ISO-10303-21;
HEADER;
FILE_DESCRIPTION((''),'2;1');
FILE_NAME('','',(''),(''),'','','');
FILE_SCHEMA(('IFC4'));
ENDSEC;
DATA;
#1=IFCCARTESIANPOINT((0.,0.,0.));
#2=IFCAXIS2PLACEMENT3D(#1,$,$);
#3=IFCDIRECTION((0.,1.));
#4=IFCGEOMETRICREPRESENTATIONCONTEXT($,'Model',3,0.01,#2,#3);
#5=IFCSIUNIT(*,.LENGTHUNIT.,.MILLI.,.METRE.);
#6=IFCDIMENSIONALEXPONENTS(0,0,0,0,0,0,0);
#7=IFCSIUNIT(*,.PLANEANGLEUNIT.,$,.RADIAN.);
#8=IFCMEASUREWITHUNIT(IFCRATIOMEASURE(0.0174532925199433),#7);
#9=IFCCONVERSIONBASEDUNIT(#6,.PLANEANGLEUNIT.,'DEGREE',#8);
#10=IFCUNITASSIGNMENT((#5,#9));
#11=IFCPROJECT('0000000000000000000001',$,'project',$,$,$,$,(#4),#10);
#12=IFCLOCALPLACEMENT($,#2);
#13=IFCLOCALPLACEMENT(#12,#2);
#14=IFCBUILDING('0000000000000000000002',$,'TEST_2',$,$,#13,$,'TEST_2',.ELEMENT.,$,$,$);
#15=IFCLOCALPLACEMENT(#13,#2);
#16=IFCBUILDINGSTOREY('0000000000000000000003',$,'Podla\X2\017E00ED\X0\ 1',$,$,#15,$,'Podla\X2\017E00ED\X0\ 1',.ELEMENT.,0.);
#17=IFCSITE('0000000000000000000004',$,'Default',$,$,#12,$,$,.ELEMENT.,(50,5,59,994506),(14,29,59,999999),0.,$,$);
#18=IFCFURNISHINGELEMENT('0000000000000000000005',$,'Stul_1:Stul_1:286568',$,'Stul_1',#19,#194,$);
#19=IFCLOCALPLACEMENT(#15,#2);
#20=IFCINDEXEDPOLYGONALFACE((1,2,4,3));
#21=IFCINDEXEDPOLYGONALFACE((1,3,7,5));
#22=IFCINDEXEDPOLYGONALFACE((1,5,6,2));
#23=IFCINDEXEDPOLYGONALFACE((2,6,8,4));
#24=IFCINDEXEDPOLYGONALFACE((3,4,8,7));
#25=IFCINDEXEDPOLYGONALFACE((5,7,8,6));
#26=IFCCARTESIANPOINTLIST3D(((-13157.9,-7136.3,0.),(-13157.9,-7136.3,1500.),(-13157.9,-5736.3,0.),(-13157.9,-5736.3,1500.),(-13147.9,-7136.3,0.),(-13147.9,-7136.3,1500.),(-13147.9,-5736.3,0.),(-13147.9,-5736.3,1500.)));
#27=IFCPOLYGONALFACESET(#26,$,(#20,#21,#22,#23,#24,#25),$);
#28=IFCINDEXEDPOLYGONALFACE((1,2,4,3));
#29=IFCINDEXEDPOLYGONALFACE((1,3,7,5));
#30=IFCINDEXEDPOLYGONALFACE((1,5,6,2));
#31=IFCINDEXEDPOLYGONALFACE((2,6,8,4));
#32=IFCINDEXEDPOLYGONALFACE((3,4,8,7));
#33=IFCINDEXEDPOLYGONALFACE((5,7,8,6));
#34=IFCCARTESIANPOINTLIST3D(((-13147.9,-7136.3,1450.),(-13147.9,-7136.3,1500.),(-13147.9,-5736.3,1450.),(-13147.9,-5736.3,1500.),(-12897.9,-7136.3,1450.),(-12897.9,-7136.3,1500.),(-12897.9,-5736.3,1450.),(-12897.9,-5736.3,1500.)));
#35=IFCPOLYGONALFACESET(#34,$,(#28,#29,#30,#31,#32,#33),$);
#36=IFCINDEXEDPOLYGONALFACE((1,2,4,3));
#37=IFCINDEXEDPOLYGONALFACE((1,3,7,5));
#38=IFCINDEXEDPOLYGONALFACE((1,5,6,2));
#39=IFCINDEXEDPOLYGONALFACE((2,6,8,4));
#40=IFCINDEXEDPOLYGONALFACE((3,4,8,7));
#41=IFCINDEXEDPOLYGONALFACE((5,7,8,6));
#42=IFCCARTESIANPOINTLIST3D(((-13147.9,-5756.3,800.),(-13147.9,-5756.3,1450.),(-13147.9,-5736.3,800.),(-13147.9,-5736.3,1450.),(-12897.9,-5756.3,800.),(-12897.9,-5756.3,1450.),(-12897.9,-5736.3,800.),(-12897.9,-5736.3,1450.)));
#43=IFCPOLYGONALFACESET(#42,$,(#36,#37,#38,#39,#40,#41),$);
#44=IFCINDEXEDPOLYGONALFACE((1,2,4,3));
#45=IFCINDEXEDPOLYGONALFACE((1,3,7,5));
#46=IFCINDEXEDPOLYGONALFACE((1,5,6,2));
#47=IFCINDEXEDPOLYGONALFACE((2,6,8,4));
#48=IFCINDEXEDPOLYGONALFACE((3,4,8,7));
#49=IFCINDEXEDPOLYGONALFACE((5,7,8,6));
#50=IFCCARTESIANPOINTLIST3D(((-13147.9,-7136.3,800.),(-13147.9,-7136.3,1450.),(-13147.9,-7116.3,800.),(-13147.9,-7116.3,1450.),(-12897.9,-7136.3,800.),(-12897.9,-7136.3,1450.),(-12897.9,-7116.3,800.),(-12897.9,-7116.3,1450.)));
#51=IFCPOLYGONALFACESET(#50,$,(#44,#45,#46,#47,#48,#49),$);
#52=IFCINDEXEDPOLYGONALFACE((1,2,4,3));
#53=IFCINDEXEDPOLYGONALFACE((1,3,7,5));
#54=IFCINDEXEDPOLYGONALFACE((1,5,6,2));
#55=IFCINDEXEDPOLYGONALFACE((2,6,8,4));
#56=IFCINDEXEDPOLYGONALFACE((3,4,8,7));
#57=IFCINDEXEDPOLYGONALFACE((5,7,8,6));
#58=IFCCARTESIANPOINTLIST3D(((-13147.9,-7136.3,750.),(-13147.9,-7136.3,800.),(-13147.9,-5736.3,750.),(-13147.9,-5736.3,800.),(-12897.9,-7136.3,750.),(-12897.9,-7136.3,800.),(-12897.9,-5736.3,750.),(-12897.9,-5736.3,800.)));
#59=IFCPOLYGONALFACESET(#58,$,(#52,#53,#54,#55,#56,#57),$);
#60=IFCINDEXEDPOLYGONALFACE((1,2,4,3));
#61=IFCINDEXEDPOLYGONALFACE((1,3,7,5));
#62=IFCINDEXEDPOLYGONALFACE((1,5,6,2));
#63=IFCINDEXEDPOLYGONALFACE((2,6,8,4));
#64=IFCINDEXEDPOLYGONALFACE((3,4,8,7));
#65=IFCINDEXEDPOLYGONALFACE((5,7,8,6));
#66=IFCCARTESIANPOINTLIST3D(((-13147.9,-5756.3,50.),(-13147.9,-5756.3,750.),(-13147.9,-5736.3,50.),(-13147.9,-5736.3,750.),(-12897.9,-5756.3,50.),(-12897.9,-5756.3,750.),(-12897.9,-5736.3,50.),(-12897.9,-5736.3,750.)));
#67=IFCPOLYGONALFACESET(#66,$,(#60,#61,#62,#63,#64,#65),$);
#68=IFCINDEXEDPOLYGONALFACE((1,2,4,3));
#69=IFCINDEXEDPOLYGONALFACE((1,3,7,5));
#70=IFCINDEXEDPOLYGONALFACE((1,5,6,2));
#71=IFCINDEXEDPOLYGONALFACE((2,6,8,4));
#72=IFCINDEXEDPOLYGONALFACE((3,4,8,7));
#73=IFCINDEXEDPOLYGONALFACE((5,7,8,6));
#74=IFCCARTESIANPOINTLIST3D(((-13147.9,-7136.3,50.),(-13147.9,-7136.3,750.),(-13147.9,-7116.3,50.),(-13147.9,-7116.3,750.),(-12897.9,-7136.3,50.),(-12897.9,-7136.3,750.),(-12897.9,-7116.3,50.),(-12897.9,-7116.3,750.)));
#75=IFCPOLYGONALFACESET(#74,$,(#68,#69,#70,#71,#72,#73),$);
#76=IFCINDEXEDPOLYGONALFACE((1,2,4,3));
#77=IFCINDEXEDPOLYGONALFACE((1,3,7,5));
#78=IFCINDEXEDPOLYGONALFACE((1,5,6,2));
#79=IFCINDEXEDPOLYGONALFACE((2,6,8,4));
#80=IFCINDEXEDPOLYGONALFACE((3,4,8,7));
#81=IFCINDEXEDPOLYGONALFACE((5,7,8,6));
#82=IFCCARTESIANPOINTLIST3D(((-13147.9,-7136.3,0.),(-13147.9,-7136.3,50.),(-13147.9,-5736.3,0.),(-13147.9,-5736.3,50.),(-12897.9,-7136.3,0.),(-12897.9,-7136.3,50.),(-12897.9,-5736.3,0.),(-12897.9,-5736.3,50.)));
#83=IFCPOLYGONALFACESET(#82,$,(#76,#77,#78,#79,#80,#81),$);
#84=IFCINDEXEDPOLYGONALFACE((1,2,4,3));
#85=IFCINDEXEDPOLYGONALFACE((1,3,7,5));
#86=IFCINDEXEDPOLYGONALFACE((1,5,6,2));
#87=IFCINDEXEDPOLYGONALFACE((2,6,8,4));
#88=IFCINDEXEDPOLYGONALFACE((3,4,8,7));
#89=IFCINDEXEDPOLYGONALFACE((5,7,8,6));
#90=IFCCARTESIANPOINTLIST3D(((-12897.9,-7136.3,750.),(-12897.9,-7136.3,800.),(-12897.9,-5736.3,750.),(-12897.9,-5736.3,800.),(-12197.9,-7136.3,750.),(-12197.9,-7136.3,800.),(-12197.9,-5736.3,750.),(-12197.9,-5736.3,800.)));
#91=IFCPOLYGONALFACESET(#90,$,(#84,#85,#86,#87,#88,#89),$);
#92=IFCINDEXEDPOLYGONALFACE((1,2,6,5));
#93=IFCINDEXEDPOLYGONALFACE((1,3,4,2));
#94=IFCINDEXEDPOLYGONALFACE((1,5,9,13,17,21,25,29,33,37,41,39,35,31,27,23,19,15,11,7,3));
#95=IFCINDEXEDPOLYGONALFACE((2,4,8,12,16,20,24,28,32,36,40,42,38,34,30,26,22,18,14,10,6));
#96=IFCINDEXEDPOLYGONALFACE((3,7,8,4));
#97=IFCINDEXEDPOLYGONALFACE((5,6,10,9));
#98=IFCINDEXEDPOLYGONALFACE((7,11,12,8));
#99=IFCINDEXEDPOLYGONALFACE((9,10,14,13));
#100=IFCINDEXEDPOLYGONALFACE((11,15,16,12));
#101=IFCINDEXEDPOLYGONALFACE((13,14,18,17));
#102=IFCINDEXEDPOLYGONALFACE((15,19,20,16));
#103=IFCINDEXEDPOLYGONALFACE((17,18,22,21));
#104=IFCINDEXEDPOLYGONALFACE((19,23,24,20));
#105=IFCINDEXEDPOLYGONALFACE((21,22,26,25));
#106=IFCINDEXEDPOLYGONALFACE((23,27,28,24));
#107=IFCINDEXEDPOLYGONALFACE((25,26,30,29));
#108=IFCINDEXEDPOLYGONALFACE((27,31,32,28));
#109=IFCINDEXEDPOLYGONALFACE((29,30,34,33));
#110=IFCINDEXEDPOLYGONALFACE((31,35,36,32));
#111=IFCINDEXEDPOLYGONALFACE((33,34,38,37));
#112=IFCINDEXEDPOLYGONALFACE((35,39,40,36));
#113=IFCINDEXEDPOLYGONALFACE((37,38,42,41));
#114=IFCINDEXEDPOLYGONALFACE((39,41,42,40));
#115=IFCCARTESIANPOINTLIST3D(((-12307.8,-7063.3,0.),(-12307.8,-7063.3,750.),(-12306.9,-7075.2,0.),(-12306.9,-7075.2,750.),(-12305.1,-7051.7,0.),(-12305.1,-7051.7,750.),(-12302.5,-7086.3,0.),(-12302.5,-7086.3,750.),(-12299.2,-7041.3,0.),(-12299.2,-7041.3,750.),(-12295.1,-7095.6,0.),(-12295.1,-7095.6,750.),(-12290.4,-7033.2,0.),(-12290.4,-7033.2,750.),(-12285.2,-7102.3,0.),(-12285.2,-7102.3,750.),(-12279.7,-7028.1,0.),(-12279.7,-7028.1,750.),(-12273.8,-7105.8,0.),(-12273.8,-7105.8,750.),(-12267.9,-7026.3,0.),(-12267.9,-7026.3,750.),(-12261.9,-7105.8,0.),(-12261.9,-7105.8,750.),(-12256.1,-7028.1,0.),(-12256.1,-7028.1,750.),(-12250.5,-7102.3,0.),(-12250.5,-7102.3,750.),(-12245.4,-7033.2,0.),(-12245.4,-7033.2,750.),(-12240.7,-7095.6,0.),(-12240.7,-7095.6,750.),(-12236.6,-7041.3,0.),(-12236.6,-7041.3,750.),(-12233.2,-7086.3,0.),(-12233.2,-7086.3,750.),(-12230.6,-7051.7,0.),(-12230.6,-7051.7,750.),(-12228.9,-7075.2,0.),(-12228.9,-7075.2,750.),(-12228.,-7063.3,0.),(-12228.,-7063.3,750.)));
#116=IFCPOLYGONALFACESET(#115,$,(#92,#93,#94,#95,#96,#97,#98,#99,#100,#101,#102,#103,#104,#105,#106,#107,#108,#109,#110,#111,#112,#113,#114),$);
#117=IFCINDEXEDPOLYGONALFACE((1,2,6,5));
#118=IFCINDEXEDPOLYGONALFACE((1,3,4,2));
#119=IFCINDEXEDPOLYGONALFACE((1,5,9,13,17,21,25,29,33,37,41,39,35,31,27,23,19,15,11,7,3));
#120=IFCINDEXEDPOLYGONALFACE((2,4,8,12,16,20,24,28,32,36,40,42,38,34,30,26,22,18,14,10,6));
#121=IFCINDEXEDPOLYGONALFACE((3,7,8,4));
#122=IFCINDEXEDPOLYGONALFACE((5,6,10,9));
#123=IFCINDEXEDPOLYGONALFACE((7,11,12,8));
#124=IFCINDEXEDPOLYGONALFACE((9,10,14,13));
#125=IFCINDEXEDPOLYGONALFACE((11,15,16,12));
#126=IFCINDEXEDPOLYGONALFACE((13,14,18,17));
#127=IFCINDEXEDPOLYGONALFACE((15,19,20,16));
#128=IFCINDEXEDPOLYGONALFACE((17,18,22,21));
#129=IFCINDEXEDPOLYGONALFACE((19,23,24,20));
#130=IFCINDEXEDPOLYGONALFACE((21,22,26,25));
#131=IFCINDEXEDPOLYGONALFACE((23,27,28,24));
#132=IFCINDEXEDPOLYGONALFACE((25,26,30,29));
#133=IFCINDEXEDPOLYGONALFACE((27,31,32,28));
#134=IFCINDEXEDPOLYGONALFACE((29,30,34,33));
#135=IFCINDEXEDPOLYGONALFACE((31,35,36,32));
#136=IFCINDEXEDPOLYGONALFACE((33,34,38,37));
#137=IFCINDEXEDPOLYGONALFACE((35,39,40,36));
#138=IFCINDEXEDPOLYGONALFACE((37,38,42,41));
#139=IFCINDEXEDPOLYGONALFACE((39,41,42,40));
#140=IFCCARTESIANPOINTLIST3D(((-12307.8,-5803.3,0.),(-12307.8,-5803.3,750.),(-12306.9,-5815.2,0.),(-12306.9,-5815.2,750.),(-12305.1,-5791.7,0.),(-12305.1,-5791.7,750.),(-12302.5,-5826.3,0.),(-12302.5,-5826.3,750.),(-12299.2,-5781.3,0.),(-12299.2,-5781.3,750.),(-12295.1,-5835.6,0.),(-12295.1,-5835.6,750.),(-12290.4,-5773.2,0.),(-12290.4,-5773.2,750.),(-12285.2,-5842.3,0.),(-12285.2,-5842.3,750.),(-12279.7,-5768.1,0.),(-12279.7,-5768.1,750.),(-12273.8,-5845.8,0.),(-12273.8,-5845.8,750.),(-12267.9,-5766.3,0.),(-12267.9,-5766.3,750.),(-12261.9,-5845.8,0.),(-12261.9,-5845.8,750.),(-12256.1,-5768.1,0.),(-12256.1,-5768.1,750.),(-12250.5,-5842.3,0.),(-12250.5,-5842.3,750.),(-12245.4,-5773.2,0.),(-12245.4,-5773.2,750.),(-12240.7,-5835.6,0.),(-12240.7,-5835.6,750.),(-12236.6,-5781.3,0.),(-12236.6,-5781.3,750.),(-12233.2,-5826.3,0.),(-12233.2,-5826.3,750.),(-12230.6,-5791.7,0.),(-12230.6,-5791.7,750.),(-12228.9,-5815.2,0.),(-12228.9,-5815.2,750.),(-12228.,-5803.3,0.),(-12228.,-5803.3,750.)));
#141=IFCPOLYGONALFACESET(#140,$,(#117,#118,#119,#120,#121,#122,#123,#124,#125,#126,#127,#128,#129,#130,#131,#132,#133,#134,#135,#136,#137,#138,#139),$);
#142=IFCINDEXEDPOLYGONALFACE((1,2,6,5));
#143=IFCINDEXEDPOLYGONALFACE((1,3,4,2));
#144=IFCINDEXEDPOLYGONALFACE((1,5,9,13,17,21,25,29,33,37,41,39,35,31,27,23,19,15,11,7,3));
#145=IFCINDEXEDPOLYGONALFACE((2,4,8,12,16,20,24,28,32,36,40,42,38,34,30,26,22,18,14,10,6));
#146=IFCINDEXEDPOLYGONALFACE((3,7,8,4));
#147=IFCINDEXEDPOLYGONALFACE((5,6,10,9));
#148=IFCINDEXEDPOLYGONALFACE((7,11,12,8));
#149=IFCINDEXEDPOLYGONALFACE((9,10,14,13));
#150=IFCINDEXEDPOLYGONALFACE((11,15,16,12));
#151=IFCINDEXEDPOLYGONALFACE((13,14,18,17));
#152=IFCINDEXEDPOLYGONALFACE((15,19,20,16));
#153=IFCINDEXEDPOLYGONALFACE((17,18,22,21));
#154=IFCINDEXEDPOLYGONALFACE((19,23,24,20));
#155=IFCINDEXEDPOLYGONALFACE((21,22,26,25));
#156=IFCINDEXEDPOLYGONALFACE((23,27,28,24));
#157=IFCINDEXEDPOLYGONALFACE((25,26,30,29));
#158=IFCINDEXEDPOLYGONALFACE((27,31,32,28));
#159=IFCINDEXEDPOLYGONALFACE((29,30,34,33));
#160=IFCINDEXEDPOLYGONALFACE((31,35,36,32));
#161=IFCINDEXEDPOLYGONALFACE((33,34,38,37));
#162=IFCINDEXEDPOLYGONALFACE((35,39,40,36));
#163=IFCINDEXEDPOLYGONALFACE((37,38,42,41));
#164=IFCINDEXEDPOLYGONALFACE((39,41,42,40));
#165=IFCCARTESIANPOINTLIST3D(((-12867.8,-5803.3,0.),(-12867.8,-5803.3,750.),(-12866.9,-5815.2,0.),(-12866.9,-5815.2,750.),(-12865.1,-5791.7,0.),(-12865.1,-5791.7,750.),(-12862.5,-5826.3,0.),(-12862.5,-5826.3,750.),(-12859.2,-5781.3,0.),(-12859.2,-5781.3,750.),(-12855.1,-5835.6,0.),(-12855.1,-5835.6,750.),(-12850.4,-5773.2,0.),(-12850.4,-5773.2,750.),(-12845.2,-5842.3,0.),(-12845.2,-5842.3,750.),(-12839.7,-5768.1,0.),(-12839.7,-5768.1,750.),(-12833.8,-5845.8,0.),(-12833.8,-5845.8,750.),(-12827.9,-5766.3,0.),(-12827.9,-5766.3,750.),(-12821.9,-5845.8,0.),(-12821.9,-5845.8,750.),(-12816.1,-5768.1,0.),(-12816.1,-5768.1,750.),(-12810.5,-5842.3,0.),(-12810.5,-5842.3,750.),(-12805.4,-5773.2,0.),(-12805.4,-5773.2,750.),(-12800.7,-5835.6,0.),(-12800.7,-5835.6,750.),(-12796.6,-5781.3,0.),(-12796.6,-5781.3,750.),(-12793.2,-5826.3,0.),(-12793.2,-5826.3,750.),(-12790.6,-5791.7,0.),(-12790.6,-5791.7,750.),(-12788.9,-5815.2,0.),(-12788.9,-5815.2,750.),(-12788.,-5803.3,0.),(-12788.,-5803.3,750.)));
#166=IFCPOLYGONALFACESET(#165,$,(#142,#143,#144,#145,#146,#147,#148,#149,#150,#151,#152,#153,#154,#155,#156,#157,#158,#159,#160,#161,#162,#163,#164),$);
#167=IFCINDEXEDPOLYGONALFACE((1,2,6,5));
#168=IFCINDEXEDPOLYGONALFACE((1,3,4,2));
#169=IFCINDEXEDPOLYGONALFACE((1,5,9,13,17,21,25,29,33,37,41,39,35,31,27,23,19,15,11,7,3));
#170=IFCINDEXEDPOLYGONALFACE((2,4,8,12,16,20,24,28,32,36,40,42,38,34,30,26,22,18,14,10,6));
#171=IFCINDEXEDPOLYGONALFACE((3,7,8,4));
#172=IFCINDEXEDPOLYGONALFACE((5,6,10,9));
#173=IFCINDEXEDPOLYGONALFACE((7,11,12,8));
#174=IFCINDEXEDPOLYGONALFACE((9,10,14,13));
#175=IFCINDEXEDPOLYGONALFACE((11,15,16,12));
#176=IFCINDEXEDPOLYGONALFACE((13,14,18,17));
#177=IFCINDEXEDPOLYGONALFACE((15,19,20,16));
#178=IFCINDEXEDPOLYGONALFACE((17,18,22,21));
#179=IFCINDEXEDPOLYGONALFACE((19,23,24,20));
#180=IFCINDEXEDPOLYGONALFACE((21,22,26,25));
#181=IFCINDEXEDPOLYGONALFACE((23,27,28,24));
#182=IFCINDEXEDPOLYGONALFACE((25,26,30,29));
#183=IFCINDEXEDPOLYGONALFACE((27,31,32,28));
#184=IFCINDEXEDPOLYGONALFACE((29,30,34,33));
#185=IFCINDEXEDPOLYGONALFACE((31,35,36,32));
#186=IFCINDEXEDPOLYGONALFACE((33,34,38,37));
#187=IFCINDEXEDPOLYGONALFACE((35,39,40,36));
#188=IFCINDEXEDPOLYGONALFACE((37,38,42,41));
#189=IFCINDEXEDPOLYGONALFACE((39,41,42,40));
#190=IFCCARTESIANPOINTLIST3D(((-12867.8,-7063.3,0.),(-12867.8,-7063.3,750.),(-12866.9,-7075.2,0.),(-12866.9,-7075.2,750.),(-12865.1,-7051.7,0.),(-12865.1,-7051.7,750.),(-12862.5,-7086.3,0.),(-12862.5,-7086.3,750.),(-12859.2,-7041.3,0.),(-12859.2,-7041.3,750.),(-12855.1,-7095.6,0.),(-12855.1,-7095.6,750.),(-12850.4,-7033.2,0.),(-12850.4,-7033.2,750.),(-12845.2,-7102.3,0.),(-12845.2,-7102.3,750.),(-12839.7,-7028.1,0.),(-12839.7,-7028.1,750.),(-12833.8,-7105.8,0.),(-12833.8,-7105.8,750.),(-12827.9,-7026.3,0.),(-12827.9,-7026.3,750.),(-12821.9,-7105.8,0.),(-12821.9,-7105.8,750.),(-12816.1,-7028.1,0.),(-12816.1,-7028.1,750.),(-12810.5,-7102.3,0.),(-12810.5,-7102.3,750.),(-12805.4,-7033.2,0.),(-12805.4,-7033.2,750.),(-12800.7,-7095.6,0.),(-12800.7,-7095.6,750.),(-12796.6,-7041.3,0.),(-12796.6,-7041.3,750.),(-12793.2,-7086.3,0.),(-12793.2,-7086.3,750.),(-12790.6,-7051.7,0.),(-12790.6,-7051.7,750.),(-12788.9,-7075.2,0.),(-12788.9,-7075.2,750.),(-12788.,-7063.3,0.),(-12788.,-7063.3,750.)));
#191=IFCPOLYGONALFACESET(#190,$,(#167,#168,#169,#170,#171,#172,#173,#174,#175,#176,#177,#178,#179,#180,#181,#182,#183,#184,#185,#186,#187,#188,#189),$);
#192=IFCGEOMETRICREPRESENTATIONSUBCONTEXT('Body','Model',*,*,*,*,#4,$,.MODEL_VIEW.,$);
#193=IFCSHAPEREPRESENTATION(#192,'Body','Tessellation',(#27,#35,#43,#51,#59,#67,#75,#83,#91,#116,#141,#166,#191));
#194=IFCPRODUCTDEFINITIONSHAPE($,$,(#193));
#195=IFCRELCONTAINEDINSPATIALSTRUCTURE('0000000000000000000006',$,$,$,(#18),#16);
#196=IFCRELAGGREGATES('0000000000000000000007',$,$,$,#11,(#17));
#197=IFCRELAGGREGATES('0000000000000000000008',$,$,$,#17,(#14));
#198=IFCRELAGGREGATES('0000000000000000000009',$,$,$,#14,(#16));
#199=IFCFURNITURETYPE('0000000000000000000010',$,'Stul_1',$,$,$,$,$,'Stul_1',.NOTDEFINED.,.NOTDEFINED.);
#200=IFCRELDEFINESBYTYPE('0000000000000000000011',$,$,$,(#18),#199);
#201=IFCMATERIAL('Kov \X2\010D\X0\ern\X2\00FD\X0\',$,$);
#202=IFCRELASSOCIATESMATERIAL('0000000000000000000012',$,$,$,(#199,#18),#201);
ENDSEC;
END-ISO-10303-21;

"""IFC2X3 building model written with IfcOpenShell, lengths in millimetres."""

from ifc_helpers import new_model, entity, si_unit, converted_unit, direction, frame, frame_2d, origin, origin_2d_with_axis, place, context, subcontext, project, spatial, rectangle, circle, extrude, source, transform, mapped, material, type_object, type_shapes, element, save


model = new_model("IFC2X3")

# Units and contexts
model_context = context("Model", 3, precision=0.01, world=origin(), true_north=direction((0.0, 1.0)))
body_context = subcontext(model_context, "Body", "Model", "MODEL_VIEW")
ifc_project = project(units=[si_unit("LENGTHUNIT", "METRE", prefix="MILLI"), converted_unit("PLANEANGLEUNIT", "DEGREE", entity("IfcRatioMeasure", 0.0174532925199433), si_unit("PLANEANGLEUNIT", "RADIAN"), dimensions=[0, 0, 0, 0, 0, 0, 0])], contexts=[model_context])

# Site, building, storey
site_placement = place(None, origin())
site = spatial("IfcSite", under=ifc_project, at=site_placement, Name="Default", CompositionType="ELEMENT", RefLatitude=(50, 5, 59, 994506), RefLongitude=(14, 29, 59, 999999), RefElevation=0.0)
building_placement = place(site_placement, origin())
building = spatial("IfcBuilding", under=site, at=building_placement, Name="TEST_2", LongName="TEST_2", CompositionType="ELEMENT")
storey_placement = place(building_placement, origin())
storey = spatial("IfcBuildingStorey", under=building, at=storey_placement, Name="Podlaží 1", LongName="Podlaží 1", CompositionType="ELEMENT", Elevation=0.0)

# Furnishing element
ifc_material_1 = material(Name="Kov černý")
furniture_type = type_object("IfcFurnitureType", Name="Stul_1", ElementType="Stul_1", material=ifc_material_1)
shared_shape_1 = source(origin(), body_context, "Body", "SweptSolid", [
    extrude(rectangle(XDim=1400.0, YDim=10.0, at=origin_2d_with_axis()), frame((0.0, 605.0, 0.0), z_axis=(0.0, 0.0, 1.0), x_axis=(-1.0, 0.0, 0.0)), (0.0, 0.0, 1.0), 1500.0),
    extrude(rectangle(XDim=1400.0, YDim=250.0, at=frame_2d((0.0, 0.0), x_axis=(1.0, 0.0))), frame((0.0, 475.0, 1450.0), z_axis=(0.0, 0.0, 1.0), x_axis=(-1.0, 0.0, 0.0)), (0.0, 0.0, 1.0), 50.0),
    extrude(rectangle(XDim=20.0, YDim=250.0, at=origin_2d_with_axis()), frame((690.0, 475.0, 800.0), z_axis=(0.0, 0.0, 1.0), x_axis=(-1.0, 0.0, 0.0)), (0.0, 0.0, 1.0), 650.0),
    extrude(rectangle(XDim=20.0, YDim=250.0, at=frame_2d((0.0, 0.0), x_axis=(1.0, 0.0))), frame((-690.0, 475.0, 800.0), z_axis=(0.0, 0.0, 1.0), x_axis=(-1.0, 0.0, 0.0)), (0.0, 0.0, 1.0), 650.0),
    extrude(rectangle(XDim=1400.0, YDim=250.0, at=origin_2d_with_axis()), frame((0.0, 475.0, 750.0), z_axis=(0.0, 0.0, 1.0), x_axis=(-1.0, 0.0, 0.0)), (0.0, 0.0, 1.0), 50.0),
    extrude(rectangle(XDim=20.0, YDim=250.0, at=origin_2d_with_axis()), frame((690.0, 475.0, 50.0), z_axis=(0.0, 0.0, 1.0), x_axis=(-1.0, 0.0, 0.0)), (0.0, 0.0, 1.0), 700.0),
    extrude(rectangle(XDim=20.0, YDim=250.0, at=frame_2d((0.0, 0.0), x_axis=(1.0, 0.0))), frame((-690.0, 475.0, 50.0), z_axis=(0.0, 0.0, 1.0), x_axis=(-1.0, 0.0, 0.0)), (0.0, 0.0, 1.0), 700.0),
    extrude(rectangle(XDim=1400.0, YDim=250.0, at=origin_2d_with_axis()), frame((0.0, 475.0, 0.0), z_axis=(0.0, 0.0, 1.0), x_axis=(-1.0, 0.0, 0.0)), (0.0, 0.0, 1.0), 50.0),
    extrude(rectangle(XDim=1400.0, YDim=700.0, at=origin_2d_with_axis()), frame((0.0, 0.0, 750.0), z_axis=(0.0, 0.0, 1.0), x_axis=(-1.0, 0.0, 0.0)), (0.0, 0.0, 1.0), 50.0),
    extrude(circle(Radius=40.0, at=frame_2d((0.0, 0.0), x_axis=(1.0, 0.0))), frame((-630.0, -280.0, 0.0)), (0.0, 0.0, 1.0), 750.0),
    extrude(circle(Radius=40.0, at=frame_2d((0.0, 0.0), x_axis=(1.0, 0.0))), frame((630.0, -280.0, 0.0)), (0.0, 0.0, 1.0), 750.0),
    extrude(circle(Radius=40.0, at=frame_2d((0.0, 0.0), x_axis=(1.0, 0.0))), frame((630.0, 280.0, 0.0)), (0.0, 0.0, 1.0), 750.0),
    extrude(circle(Radius=40.0, at=frame_2d((0.0, 0.0), x_axis=(1.0, 0.0))), frame((-630.0, 280.0, 0.0)), (0.0, 0.0, 1.0), 750.0),
])
type_shapes(furniture_type, [shared_shape_1])
for number, where, z_axis, x_axis, name in (
    (1, (-12547.9, -6436.3, 0.0), (0.0, 0.0, 1.0), (0.0, 1.0, 0.0), "Stul_1:Stul_1:286568"),
):
    element("IfcFurnishingElement", number, at=place(storey_placement, frame(where, z_axis=z_axis, x_axis=x_axis)), inside=storey, type_object=furniture_type, material=ifc_material_1, Name=name, ObjectType="Stul_1", context=body_context, shape_type="MappedRepresentation", body=[
        mapped(shared_shape_1, transform((0.0, 0.0, 0.0), scale=1.0)),
    ])

save(model, "model.ifc")
